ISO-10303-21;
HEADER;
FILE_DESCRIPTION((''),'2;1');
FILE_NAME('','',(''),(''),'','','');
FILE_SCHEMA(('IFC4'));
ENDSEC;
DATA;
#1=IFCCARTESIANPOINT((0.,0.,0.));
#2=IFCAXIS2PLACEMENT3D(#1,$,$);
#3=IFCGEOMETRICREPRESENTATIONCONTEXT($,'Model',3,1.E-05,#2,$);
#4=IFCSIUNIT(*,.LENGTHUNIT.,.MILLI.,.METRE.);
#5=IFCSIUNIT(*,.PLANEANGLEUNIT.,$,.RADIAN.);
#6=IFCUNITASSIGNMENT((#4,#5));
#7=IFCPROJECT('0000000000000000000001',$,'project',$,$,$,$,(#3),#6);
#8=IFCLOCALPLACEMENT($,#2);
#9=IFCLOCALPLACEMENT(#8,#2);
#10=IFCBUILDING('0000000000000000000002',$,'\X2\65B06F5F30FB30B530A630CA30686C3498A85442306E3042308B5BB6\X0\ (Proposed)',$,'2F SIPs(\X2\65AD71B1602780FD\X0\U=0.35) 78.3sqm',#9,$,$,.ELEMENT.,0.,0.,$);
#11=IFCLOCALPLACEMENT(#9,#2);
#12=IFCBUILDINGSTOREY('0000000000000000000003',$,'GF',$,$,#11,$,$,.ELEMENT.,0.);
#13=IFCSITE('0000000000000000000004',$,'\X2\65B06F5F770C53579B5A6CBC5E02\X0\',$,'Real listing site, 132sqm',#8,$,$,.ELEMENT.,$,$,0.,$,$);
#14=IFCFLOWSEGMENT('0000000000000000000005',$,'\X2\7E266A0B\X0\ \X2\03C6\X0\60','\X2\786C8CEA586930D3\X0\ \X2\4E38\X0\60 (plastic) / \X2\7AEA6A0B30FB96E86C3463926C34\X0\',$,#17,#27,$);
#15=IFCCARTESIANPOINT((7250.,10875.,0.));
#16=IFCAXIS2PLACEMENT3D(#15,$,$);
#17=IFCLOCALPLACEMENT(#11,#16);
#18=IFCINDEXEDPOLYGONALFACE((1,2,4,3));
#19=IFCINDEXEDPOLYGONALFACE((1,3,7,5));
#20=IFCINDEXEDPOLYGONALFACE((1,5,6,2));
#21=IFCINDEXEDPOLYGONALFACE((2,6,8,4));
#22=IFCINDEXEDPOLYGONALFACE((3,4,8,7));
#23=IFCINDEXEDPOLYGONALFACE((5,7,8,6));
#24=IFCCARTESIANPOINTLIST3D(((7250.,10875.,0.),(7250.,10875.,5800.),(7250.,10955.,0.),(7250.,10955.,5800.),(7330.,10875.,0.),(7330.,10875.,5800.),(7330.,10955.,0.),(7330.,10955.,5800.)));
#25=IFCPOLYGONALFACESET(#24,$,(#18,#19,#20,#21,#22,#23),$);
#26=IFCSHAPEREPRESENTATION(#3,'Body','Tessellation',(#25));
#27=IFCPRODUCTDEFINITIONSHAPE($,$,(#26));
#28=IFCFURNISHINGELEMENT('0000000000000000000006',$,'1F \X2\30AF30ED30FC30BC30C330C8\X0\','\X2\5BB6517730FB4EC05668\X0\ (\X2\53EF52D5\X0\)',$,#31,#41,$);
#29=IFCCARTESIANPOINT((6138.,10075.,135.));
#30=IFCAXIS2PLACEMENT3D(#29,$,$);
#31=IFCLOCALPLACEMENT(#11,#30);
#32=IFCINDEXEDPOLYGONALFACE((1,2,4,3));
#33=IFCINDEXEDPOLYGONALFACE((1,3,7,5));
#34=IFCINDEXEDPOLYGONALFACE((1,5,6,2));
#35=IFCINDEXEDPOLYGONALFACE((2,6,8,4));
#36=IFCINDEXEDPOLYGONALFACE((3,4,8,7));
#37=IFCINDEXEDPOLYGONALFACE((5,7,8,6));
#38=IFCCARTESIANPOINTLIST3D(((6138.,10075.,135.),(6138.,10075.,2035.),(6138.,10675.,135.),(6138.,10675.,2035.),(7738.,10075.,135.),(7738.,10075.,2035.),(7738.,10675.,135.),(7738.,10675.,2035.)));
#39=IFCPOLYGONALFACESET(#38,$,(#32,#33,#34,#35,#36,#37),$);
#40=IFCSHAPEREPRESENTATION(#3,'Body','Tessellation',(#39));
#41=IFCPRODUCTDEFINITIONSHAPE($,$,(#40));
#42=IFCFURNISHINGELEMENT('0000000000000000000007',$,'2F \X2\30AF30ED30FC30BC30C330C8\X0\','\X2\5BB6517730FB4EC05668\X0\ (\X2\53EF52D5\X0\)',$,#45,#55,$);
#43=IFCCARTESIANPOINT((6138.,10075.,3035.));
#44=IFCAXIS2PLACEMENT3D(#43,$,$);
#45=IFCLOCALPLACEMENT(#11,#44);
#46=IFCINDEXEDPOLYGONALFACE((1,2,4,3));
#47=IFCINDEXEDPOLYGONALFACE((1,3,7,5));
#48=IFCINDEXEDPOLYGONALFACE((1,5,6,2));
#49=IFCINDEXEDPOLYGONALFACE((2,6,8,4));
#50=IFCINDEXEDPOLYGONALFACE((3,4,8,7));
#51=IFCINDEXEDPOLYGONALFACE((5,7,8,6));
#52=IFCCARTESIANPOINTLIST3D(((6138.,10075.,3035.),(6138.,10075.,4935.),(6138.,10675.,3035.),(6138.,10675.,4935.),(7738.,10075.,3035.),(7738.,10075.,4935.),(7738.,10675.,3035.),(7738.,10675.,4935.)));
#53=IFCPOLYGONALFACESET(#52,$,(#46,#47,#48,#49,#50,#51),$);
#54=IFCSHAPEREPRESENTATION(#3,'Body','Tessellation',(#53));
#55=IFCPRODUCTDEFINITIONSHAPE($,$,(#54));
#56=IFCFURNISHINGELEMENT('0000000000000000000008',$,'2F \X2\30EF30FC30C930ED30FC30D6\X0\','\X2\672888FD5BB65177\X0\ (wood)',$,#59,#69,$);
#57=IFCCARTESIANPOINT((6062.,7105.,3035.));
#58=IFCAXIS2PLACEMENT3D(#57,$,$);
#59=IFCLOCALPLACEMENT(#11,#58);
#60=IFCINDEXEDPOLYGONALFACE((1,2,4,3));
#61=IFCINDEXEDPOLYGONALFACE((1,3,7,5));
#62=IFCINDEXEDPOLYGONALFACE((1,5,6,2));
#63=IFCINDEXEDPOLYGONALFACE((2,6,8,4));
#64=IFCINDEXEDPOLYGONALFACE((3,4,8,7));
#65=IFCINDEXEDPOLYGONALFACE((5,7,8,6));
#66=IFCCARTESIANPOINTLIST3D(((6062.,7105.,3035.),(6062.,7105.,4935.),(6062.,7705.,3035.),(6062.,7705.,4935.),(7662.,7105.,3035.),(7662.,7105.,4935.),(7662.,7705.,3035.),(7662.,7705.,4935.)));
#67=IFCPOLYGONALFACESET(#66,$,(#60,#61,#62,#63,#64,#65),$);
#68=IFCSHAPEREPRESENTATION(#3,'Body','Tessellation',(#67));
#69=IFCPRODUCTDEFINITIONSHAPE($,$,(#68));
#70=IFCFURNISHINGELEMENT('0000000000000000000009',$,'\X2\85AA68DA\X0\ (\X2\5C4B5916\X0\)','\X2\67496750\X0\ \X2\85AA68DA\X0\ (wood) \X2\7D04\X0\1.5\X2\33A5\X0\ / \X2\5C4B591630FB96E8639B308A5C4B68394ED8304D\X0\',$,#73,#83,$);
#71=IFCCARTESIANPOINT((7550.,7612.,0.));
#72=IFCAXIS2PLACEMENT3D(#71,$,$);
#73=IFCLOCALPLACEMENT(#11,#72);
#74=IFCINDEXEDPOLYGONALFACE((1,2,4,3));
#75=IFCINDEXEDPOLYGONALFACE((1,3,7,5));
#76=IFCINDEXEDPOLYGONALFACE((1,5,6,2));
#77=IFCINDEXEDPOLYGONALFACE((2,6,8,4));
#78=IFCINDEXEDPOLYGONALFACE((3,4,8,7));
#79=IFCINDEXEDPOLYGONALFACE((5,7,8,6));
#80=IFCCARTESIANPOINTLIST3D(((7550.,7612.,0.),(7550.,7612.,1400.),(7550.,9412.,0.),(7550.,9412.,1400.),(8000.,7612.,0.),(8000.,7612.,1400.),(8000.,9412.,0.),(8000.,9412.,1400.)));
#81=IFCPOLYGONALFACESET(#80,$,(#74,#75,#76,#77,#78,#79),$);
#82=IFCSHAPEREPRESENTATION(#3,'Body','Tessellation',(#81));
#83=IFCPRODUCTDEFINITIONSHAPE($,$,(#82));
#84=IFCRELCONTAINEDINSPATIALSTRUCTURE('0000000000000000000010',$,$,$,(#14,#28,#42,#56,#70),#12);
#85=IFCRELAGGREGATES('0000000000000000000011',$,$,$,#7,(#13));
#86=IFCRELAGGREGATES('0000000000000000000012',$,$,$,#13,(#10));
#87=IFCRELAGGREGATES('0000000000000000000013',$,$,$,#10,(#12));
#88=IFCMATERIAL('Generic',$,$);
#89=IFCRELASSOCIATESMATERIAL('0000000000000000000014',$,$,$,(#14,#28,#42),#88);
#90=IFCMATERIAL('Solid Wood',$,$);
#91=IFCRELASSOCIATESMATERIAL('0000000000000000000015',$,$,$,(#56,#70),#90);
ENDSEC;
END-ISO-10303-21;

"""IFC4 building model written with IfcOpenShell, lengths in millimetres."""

from ifc_helpers import new_model, si_unit, frame, frame_2d, origin, place, context, project, spatial, rectangle, extrude, material, element, save


model = new_model("IFC4")

# Units and contexts
model_context = context("Model", 3, precision=1e-05, world=origin())
ifc_project = project(units=[si_unit("LENGTHUNIT", "METRE", prefix="MILLI"), si_unit("PLANEANGLEUNIT", "RADIAN")], contexts=[model_context])

# Site, building, storey
site_placement = place(None, origin())
site = spatial("IfcSite", under=ifc_project, at=site_placement, Name="新潟県南魚沼市", ObjectType="Real listing site, 132sqm", CompositionType="ELEMENT", RefElevation=0.0)
building_placement = place(site_placement, origin())
building = spatial("IfcBuilding", under=site, at=building_placement, Name="新潟・サウナと水風呂のある家 (Proposed)", ObjectType="2F SIPs(断熱性能U=0.35) 78.3sqm", CompositionType="ELEMENT", ElevationOfRefHeight=0.0, ElevationOfTerrain=0.0)
storey_placement = place(building_placement, origin())
storey = spatial("IfcBuildingStorey", under=building, at=storey_placement, Name="GF", CompositionType="ELEMENT", Elevation=0.0)

# Shared definitions
ifc_material_1 = material(Name="Solid Wood")

# Shared definitions
ifc_material_2 = material(Name="Generic")

# Flow segment
flow_segment_placement = place(storey_placement, frame((7250.0, 10875.0, 0.0)))
element("IfcFlowSegment", 1, at=flow_segment_placement, inside=storey, material=ifc_material_2, Name="縦樋 φ60", Description="硬質塩ビ 丸60 (plastic) / 竪樋・雨水排水", context=model_context, shape_type="SweptSolid", body=[
    extrude(rectangle(XDim=80.0, YDim=80.0, at=frame_2d((40.0, 40.0))), frame((7250.0, 10875.0, 0.0)), (0.0, 0.0, 1.0), 5800.0),
])

# Furnishing elements
furnishing_1_placement = place(storey_placement, frame((6138.0, 10075.0, 135.0)))
element("IfcFurnishingElement", 2, at=furnishing_1_placement, inside=storey, material=ifc_material_2, Name="1F クローゼット", Description="家具・什器 (可動)", context=model_context, shape_type="SweptSolid", body=[
    extrude(rectangle(XDim=1600.0, YDim=600.0, at=frame_2d((800.0, 300.0))), frame((6138.0, 10075.0, 135.0)), (0.0, 0.0, 1.0), 1900.0),
])
furnishing_2_placement = place(storey_placement, frame((6138.0, 10075.0, 3035.0)))
element("IfcFurnishingElement", 3, at=furnishing_2_placement, inside=storey, material=ifc_material_2, Name="2F クローゼット", Description="家具・什器 (可動)", context=model_context, shape_type="SweptSolid", body=[
    extrude(rectangle(XDim=1600.0, YDim=600.0, at=frame_2d((800.0, 300.0))), frame((6138.0, 10075.0, 3035.0)), (0.0, 0.0, 1.0), 1900.0),
])
furnishing_3_placement = place(storey_placement, frame((6062.0, 7105.0, 3035.0)))
element("IfcFurnishingElement", 4, at=furnishing_3_placement, inside=storey, material=ifc_material_1, Name="2F ワードローブ", Description="木製家具 (wood)", context=model_context, shape_type="SweptSolid", body=[
    extrude(rectangle(XDim=1600.0, YDim=600.0, at=frame_2d((800.0, 300.0))), frame((6062.0, 7105.0, 3035.0)), (0.0, 0.0, 1.0), 1900.0),
])
furnishing_4_placement = place(storey_placement, frame((7550.0, 7612.0, 0.0)))
element("IfcFurnishingElement", 5, at=furnishing_4_placement, inside=storey, material=ifc_material_1, Name="薪棚 (屋外)", Description="杉材 薪棚 (wood) 約1.5㎥ / 屋外・雨掛り屋根付き", context=model_context, shape_type="SweptSolid", body=[
    extrude(rectangle(XDim=450.0, YDim=1800.0, at=frame_2d((225.0, 900.0))), frame((7550.0, 7612.0, 0.0)), (0.0, 0.0, 1.0), 1400.0),
])

save(model, "model.ifc")
